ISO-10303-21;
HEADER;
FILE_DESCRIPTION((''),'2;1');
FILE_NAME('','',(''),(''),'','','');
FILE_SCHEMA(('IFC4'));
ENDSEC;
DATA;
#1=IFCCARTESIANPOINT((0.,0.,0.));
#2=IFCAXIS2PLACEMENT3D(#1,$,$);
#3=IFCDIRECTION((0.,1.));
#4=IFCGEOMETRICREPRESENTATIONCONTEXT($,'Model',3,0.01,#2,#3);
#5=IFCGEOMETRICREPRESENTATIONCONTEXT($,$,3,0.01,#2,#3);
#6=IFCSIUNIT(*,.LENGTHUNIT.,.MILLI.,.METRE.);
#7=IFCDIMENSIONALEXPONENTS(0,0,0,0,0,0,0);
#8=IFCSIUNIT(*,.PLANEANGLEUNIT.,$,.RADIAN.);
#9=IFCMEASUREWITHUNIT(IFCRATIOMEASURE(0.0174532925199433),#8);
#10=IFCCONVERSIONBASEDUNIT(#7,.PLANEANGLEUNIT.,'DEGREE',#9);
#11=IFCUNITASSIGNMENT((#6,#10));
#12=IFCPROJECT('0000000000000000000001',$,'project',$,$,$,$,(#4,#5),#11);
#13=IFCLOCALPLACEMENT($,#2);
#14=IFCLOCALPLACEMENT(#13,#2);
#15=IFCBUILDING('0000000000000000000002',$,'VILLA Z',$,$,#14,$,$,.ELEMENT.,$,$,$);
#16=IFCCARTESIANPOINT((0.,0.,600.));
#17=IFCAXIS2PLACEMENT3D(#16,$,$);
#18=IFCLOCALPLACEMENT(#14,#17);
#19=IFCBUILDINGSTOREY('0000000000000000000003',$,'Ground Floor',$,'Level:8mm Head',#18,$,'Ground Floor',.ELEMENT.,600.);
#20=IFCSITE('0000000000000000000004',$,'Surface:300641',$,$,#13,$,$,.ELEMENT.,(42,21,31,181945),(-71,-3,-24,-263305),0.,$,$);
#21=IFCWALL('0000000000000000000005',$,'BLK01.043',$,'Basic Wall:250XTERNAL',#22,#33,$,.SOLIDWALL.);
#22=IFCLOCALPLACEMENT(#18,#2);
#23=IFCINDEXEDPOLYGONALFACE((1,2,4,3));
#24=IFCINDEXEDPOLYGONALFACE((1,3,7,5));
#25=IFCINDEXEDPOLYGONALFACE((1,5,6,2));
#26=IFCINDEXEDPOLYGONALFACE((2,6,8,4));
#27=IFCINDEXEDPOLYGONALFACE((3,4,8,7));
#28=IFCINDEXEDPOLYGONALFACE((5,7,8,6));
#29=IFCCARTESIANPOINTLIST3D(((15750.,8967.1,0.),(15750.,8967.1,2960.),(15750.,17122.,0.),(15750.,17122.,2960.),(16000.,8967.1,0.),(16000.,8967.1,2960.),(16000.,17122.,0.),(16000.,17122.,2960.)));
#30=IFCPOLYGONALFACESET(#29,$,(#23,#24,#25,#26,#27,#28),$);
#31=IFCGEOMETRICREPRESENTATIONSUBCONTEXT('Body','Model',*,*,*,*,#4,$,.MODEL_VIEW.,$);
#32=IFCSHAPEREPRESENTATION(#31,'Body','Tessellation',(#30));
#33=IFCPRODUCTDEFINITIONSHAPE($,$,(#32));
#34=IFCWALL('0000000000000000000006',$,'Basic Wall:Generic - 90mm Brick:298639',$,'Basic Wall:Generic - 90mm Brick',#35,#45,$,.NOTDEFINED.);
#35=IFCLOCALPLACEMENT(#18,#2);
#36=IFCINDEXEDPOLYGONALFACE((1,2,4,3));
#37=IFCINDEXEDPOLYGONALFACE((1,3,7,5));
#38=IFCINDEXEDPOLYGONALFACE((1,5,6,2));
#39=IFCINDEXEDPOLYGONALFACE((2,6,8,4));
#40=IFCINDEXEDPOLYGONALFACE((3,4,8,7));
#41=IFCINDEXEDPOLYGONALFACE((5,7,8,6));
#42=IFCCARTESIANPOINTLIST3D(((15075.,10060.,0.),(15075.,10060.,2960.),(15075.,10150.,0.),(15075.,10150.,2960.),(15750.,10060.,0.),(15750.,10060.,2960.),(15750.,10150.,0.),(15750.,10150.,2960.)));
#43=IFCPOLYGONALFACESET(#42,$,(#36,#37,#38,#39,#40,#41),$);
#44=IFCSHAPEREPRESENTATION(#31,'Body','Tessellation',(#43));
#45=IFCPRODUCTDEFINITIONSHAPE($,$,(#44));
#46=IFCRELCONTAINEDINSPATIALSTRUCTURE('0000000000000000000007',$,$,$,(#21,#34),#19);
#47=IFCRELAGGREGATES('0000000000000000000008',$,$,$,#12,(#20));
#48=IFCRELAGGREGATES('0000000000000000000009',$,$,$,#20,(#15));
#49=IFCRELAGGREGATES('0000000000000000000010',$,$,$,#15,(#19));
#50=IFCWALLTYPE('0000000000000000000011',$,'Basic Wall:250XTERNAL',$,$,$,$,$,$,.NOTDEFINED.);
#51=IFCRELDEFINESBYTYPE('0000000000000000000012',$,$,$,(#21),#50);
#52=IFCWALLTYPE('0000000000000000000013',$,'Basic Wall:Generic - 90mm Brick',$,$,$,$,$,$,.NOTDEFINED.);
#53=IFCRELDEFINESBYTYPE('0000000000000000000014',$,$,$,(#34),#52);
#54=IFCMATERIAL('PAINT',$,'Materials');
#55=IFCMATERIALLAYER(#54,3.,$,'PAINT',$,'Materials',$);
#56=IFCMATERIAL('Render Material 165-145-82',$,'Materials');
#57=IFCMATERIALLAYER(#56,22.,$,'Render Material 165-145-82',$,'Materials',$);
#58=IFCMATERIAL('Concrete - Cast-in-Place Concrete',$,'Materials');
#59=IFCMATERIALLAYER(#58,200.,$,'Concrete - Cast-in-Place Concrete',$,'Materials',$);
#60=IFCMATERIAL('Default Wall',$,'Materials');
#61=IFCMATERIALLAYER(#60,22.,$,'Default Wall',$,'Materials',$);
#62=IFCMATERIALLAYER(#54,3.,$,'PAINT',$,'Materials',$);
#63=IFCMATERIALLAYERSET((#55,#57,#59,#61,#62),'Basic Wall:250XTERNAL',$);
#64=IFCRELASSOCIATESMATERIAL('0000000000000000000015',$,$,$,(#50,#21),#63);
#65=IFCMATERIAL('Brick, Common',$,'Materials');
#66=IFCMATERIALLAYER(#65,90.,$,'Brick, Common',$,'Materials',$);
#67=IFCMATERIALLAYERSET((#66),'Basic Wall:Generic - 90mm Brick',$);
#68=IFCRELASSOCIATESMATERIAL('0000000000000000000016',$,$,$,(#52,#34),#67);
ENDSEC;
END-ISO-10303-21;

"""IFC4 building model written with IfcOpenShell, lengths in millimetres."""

from ifc_helpers import new_model, entity, si_unit, converted_unit, direction, frame, frame_2d, origin, place, context, subcontext, project, spatial, polyline, rectangle, extrude, clip, halfspace, bounded_halfspace, material, layer, layer_set, layer_usage, type_object, element, save


model = new_model("IFC4")

# Units and contexts
model_context = context("Model", 3, precision=0.01, world=origin(), true_north=direction((0.0, 1.0)))
context_of_model = context(None, 3, precision=0.01, world=origin(), true_north=direction((0.0, 1.0)))
body_context = subcontext(model_context, "Body", "Model", "MODEL_VIEW")
ifc_project = project(units=[si_unit("LENGTHUNIT", "METRE", prefix="MILLI"), converted_unit("PLANEANGLEUNIT", "DEGREE", entity("IfcRatioMeasure", 0.0174532925199433), si_unit("PLANEANGLEUNIT", "RADIAN"), dimensions=[0, 0, 0, 0, 0, 0, 0])], contexts=[model_context, context_of_model])

# Site, building, storey
site_placement = place(None, origin())
site = spatial("IfcSite", under=ifc_project, at=site_placement, Name="Surface:300641", CompositionType="ELEMENT", RefLatitude=(42, 21, 31, 181945), RefLongitude=(-71, -3, -24, -263305), RefElevation=0.0)
building_placement = place(site_placement, origin())
building = spatial("IfcBuilding", under=site, at=building_placement, Name="VILLA Z", CompositionType="ELEMENT")
storey_placement = place(building_placement, frame((0.0, 0.0, 600.0)))
storey = spatial("IfcBuildingStorey", under=building, at=storey_placement, Name="Ground Floor", ObjectType="Level:8mm Head", LongName="Ground Floor", CompositionType="ELEMENT", Elevation=600.0)

# Shared definitions
ifc_material_1 = material(Name="PAINT", Category="Materials")
ifc_layer_1 = layer(ifc_material_1, 3.0, Name="PAINT", Category="Materials")
ifc_material_2 = material(Name="Render Material 165-145-82", Category="Materials")
ifc_layer_2 = layer(ifc_material_2, 22.0, Name="Render Material 165-145-82", Category="Materials")
ifc_material_3 = material(Name="Concrete - Cast-in-Place Concrete", Category="Materials")
ifc_layer_3 = layer(ifc_material_3, 200.0, Name="Concrete - Cast-in-Place Concrete", Category="Materials")
ifc_material_4 = material(Name="Default Wall", Category="Materials")
ifc_layer_4 = layer(ifc_material_4, 22.0, Name="Default Wall", Category="Materials")
ifc_layer_5 = layer(ifc_material_1, 3.0, Name="PAINT", Category="Materials")
ifc_layer_set_1 = layer_set([ifc_layer_1, ifc_layer_2, ifc_layer_3, ifc_layer_4, ifc_layer_5], Name="Basic Wall:250XTERNAL")
wall_type_1 = type_object("IfcWallType", Name="Basic Wall:250XTERNAL", PredefinedType="NOTDEFINED", material=ifc_layer_set_1)

# Walls
ifc_layer_usage_1 = layer_usage(ifc_layer_set_1, "AXIS2", "NEGATIVE", 125.0)
wall_1_placement = place(storey_placement, frame((15875.0, 8967.1, 0.0), z_axis=(0.0, 0.0, 1.0), x_axis=(0.0, 1.0, 0.0)))
element("IfcWall", 1, at=wall_1_placement, inside=storey, type_object=wall_type_1, material=ifc_layer_usage_1, Name="BLK01.043", ObjectType="Basic Wall:250XTERNAL", PredefinedType="SOLIDWALL", context=body_context, shape_type="Clipping", body=[
    clip(extrude(rectangle(XDim=8154.9, YDim=250.0, at=frame_2d((4077.5, 0.0), x_axis=(-1.0, 0.0))), origin(), (0.0, 0.0, 1.0), 2960.0), bounded_halfspace(frame((0.0, -125.0, 2960.0), z_axis=(0.0, 0.0, -1.0), x_axis=(-1.0, 0.0, 0.0)), True, frame((0.0, -125.0, 2960.0)), polyline([(0.0, 0.0), (8154.9, 0.0), (8154.9, 250.0), (3042.9, 250.0), (2792.9, 250.0), (1182.9, 250.0), (1092.9, 250.0), (0.0, 250.0), (0.0, 0.0)]))),
])
ifc_material_5 = material(Name="Brick, Common", Category="Materials")
ifc_layer_6 = layer(ifc_material_5, 90.0, Name="Brick, Common", Category="Materials")
ifc_layer_set_2 = layer_set([ifc_layer_6], Name="Basic Wall:Generic - 90mm Brick")
ifc_layer_usage_2 = layer_usage(ifc_layer_set_2, "AXIS2", "NEGATIVE", 45.0)
wall_type_2 = type_object("IfcWallType", Name="Basic Wall:Generic - 90mm Brick", PredefinedType="NOTDEFINED", material=ifc_layer_set_2)
wall_2_placement = place(storey_placement, frame((15075.0, 10105.0, 0.0)))
element("IfcWall", 2, at=wall_2_placement, inside=storey, type_object=wall_type_2, material=ifc_layer_usage_2, Name="Basic Wall:Generic - 90mm Brick:298639", ObjectType="Basic Wall:Generic - 90mm Brick", PredefinedType="NOTDEFINED", context=body_context, shape_type="Clipping", body=[
    clip(clip(extrude(rectangle(XDim=675.0, YDim=90.0, at=frame_2d((337.5, 0.0), x_axis=(-1.0, 0.0))), origin(), (0.0, 0.0, 1.0), 2960.0), bounded_halfspace(frame((0.0, -45.0, 2960.0), z_axis=(0.0, 0.0, -1.0), x_axis=(0.0, -1.0, 0.0)), True, frame((0.0, -45.0, 2960.0)), polyline([(0.0, 0.0), (675.0, 0.0), (675.0, 90.0), (0.0, 90.0), (0.0, 0.0)]))), halfspace(origin(), True)),
])

save(model, "model.ifc")
